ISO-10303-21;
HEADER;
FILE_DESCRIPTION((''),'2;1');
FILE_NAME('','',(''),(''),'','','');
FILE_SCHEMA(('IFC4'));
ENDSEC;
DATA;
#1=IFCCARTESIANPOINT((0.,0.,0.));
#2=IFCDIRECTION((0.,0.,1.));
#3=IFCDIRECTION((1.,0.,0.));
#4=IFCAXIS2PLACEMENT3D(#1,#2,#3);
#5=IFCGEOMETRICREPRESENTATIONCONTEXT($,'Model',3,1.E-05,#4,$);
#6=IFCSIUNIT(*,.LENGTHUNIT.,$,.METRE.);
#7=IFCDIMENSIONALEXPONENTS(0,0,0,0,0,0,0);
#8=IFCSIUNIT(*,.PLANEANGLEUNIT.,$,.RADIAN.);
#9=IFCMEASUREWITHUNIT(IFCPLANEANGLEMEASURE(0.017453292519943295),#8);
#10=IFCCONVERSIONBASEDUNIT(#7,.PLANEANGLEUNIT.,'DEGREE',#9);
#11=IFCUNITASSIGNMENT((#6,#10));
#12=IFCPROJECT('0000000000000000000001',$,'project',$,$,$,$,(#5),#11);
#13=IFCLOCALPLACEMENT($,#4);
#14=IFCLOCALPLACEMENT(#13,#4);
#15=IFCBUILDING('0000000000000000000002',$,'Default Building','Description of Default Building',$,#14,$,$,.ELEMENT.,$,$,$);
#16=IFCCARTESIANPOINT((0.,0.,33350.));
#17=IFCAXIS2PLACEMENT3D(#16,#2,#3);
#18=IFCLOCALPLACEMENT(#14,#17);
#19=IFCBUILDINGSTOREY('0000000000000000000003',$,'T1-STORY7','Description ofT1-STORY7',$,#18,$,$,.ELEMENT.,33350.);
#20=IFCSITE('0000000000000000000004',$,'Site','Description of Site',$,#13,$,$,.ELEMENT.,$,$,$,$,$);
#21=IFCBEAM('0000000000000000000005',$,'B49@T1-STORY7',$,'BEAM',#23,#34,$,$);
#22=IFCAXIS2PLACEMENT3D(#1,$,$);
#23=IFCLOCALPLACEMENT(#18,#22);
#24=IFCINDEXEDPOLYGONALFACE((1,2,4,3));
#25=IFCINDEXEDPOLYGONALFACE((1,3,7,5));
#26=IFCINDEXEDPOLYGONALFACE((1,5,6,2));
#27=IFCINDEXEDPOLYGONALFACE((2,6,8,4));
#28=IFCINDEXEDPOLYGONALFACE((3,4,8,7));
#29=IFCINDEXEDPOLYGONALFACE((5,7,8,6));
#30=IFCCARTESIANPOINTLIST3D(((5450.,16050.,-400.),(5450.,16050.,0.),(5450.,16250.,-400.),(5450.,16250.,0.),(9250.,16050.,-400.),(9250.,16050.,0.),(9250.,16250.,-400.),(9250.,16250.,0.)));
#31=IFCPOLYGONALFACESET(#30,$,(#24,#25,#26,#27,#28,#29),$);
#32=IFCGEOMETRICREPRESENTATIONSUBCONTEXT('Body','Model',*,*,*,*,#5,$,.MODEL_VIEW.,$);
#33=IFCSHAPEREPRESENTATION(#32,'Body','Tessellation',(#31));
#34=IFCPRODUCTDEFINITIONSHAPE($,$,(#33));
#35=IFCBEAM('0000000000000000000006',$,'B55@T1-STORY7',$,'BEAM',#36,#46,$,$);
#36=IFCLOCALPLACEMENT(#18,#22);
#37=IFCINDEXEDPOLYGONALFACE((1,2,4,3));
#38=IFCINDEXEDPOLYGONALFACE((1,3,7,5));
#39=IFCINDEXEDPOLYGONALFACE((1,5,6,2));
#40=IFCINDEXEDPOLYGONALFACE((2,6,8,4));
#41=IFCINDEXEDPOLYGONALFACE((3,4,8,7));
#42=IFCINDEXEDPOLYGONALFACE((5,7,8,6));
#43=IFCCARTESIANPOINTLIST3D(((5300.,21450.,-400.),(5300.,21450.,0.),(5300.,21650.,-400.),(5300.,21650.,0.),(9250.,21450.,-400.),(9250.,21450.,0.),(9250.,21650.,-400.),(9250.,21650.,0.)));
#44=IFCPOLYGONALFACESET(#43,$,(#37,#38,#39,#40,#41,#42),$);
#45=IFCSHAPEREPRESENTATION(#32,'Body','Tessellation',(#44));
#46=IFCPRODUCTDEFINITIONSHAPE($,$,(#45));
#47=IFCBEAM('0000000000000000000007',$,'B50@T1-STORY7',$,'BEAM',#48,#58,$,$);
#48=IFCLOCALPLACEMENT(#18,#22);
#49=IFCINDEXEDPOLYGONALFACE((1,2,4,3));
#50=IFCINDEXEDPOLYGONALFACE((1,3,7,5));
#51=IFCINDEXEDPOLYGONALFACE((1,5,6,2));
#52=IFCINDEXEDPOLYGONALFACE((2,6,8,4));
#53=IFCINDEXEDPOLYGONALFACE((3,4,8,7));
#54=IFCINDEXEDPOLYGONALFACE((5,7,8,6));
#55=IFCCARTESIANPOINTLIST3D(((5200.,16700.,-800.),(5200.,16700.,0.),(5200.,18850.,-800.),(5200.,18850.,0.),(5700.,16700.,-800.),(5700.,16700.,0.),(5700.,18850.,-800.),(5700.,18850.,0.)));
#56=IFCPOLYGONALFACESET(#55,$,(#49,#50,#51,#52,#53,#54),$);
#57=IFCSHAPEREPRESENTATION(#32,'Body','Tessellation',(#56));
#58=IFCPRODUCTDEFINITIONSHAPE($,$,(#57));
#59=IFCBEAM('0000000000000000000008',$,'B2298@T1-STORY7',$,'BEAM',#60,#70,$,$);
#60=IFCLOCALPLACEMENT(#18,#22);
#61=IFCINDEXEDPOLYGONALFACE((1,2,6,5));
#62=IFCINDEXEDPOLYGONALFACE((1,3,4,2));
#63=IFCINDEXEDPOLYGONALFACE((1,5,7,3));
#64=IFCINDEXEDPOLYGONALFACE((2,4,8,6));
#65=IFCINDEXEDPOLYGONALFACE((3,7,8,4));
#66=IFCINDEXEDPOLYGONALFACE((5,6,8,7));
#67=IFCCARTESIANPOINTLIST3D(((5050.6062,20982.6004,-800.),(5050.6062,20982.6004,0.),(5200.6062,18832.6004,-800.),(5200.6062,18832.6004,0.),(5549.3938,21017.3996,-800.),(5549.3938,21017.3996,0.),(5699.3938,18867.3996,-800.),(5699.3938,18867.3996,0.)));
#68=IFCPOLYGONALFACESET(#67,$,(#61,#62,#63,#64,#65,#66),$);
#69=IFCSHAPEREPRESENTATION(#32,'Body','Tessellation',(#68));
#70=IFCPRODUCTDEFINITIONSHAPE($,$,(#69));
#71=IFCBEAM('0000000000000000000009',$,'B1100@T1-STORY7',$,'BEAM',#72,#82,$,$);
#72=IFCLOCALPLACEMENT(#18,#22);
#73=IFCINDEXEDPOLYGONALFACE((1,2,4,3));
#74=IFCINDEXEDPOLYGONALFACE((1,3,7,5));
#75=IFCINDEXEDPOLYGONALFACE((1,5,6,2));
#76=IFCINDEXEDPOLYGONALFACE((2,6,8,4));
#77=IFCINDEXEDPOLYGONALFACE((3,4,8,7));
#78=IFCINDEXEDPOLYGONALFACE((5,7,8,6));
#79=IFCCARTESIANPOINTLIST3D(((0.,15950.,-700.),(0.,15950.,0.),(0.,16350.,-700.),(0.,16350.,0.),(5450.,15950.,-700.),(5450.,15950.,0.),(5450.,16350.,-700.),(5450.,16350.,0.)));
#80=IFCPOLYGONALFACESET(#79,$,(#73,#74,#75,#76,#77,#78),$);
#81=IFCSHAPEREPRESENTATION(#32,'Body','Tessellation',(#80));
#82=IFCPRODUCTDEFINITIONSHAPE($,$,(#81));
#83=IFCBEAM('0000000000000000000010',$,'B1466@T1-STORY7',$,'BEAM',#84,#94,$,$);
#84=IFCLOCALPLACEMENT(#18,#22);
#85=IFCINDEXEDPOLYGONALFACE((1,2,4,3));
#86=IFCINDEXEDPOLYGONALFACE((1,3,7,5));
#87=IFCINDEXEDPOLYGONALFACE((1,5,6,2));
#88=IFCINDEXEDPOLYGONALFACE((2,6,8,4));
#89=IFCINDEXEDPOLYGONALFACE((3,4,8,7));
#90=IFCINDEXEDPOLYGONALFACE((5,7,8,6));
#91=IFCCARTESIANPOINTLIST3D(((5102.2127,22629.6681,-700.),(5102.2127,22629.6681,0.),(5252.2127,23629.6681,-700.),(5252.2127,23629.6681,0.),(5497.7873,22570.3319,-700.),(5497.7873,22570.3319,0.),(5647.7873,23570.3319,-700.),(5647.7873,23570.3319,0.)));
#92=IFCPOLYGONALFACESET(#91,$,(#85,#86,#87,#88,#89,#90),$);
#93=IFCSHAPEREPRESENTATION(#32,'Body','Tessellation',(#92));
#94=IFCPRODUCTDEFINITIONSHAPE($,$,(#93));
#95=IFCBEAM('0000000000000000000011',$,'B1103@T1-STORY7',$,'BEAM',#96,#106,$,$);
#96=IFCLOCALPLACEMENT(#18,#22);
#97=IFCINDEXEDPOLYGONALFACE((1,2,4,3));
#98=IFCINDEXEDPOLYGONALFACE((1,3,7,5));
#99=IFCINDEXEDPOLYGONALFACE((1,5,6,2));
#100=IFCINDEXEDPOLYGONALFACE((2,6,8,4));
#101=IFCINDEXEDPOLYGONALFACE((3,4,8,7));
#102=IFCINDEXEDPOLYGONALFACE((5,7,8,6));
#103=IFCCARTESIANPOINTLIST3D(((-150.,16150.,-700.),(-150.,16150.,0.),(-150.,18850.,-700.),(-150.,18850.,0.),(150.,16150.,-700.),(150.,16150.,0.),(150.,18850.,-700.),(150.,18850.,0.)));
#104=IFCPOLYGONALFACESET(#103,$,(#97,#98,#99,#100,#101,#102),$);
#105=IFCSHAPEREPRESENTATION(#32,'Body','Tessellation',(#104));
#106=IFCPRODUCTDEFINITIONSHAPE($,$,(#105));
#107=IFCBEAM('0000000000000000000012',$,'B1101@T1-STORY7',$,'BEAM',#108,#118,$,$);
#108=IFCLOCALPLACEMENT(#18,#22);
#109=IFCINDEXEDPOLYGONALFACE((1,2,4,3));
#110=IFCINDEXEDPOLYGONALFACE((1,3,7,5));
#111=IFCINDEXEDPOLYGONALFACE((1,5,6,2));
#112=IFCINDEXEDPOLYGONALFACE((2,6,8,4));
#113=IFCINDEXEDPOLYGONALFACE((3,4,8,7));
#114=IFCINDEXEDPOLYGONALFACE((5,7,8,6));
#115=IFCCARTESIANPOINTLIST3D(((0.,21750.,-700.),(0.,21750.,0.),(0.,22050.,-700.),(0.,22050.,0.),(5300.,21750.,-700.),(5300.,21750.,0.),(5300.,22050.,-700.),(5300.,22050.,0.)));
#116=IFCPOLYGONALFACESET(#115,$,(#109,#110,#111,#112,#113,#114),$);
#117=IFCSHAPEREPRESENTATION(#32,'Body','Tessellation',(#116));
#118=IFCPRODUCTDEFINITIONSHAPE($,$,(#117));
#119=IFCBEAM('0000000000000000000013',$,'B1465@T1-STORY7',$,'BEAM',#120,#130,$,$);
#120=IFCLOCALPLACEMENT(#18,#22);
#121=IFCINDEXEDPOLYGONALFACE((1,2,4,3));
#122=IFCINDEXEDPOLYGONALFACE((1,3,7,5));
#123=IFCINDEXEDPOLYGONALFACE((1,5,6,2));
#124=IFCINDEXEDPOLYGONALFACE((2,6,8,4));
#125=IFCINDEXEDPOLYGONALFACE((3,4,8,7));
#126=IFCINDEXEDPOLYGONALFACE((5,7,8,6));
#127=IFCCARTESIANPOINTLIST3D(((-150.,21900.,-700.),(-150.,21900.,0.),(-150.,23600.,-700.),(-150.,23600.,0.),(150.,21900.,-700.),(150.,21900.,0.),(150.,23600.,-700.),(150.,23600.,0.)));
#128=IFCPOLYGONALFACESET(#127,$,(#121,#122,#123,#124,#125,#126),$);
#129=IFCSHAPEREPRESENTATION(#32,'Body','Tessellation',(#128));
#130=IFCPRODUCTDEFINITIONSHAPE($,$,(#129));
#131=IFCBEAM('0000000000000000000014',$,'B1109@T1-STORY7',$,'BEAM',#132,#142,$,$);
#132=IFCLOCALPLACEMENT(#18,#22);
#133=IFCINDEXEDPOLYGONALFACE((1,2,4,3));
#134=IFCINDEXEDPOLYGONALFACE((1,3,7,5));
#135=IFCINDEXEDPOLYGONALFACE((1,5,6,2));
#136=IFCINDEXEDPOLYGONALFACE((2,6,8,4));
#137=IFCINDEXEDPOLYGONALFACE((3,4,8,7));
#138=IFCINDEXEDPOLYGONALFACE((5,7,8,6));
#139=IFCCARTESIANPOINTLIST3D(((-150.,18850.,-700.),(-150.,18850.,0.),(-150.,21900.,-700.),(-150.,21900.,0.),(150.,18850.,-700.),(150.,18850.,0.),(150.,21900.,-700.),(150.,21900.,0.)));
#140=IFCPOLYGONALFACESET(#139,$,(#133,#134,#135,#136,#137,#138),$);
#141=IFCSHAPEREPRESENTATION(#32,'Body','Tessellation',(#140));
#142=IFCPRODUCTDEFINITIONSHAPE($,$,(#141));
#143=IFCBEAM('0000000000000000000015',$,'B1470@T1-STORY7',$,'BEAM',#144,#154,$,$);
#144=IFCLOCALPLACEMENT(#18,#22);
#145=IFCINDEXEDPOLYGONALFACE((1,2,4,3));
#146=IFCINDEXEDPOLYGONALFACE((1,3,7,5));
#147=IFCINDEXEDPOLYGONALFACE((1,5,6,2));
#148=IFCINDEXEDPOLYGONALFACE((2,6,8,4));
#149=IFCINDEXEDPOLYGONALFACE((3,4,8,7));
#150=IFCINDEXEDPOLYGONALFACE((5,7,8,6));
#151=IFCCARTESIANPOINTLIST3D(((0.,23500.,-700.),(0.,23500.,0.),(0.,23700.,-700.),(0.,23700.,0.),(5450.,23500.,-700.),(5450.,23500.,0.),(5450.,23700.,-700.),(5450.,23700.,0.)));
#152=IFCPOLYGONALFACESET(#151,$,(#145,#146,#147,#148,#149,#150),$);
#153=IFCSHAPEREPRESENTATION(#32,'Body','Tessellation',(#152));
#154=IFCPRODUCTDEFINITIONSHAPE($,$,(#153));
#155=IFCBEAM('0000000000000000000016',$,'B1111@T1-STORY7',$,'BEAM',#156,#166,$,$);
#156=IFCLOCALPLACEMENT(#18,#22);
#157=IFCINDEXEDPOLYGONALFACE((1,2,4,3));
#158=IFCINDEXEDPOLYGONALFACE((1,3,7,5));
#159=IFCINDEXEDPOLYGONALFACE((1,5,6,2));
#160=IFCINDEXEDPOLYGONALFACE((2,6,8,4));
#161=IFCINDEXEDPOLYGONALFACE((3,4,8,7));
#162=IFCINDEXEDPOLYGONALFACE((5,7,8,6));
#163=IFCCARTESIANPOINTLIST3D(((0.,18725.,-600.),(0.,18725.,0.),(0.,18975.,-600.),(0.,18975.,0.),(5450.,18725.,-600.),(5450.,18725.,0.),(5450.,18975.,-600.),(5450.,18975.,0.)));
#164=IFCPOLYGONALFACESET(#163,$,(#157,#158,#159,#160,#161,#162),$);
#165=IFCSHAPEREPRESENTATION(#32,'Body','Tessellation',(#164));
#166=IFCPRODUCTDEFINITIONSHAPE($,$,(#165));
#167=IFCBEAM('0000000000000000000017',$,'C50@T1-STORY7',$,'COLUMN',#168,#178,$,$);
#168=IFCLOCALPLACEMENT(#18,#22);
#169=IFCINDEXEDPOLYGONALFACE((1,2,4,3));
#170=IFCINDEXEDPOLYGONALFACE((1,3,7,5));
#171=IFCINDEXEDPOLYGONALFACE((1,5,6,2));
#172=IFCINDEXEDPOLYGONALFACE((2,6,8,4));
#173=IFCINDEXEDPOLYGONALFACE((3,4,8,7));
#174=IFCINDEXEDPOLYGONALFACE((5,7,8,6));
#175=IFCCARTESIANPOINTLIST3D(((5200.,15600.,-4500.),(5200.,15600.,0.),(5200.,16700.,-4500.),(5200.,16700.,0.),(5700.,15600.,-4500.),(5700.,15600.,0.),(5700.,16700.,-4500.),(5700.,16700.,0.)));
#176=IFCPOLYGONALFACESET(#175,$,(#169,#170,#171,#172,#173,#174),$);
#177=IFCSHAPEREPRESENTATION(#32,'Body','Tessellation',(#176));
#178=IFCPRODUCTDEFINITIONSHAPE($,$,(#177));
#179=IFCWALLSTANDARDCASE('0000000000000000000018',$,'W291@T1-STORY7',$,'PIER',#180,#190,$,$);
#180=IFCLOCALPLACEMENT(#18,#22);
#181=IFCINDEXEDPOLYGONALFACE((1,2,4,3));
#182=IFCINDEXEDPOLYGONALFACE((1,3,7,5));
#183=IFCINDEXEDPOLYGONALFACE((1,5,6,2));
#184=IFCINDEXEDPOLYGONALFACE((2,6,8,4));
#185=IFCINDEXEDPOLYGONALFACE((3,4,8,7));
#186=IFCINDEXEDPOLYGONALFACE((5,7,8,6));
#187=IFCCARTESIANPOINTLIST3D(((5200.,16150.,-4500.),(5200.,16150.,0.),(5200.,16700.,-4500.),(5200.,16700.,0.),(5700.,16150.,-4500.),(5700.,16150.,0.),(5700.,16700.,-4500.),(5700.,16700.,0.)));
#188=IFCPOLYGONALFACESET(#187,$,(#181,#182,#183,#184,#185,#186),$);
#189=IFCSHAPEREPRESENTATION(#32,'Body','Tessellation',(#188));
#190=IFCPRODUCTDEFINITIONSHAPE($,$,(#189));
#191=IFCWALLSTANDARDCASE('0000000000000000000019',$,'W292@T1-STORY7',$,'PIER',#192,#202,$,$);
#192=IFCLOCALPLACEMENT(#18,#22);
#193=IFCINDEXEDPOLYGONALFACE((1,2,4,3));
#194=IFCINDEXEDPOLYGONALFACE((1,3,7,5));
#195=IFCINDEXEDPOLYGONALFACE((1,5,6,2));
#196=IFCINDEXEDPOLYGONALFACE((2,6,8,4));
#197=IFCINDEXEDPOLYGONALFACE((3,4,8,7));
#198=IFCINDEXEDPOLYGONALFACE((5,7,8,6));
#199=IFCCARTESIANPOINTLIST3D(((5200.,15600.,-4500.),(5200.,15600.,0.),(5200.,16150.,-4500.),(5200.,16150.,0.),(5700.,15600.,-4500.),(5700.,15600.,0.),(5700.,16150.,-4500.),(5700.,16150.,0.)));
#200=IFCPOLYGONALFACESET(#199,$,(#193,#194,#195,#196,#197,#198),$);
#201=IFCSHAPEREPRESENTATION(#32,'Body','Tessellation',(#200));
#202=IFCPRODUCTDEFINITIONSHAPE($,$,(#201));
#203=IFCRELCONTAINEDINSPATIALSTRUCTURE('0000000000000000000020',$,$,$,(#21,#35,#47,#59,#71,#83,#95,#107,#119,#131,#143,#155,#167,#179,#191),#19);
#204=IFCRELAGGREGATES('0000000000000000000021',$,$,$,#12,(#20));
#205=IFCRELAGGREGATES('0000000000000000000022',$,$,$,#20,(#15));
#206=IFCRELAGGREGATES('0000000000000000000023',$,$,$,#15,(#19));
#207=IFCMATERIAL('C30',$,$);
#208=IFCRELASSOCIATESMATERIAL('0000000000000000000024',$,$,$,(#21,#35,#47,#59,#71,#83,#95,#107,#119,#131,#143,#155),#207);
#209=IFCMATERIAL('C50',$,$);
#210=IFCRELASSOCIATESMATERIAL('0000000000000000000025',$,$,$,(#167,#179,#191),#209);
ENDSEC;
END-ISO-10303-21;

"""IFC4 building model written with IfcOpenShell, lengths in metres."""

from ifc_helpers import new_model, entity, si_unit, converted_unit, frame, origin_with_axes, place, context, subcontext, project, spatial, indexed_curve, rectangle, outline, extrude, material, element, save


model = new_model("IFC4")

# Units and contexts
model_context = context("Model", 3, precision=1e-05, world=origin_with_axes())
body_context = subcontext(model_context, "Body", "Model", "MODEL_VIEW")
ifc_project = project(units=[si_unit("LENGTHUNIT", "METRE"), converted_unit("PLANEANGLEUNIT", "DEGREE", entity("IfcPlaneAngleMeasure", 0.017453292519943295), si_unit("PLANEANGLEUNIT", "RADIAN"), dimensions=[0, 0, 0, 0, 0, 0, 0])], contexts=[model_context])

# Site, building, storey
site_placement = place(None, origin_with_axes())
site = spatial("IfcSite", under=ifc_project, at=site_placement, Name="Site", Description="Description of Site", CompositionType="ELEMENT")
building_placement = place(site_placement, origin_with_axes())
building = spatial("IfcBuilding", under=site, at=building_placement, Name="Default Building", Description="Description of Default Building", CompositionType="ELEMENT")
storey_placement = place(building_placement, frame((0.0, 0.0, 33350.0), z_axis=(0.0, 0.0, 1.0), x_axis=(1.0, 0.0, 0.0)))
storey = spatial("IfcBuildingStorey", under=building, at=storey_placement, Name="T1-STORY7", Description="Description ofT1-STORY7", CompositionType="ELEMENT", Elevation=33350.0)

# Beams
ifc_material_1 = material(Name="C30")
beam_1_placement = place(storey_placement, frame((5450.0, 16150.0, -200.0), z_axis=(1.0, 0.0, 0.0), x_axis=(0.0, 1.0, 0.0)))
element("IfcBeam", 1, at=beam_1_placement, inside=storey, material=ifc_material_1, Name="B49@T1-STORY7", ObjectType="BEAM", context=body_context, shape_type="SweptSolid", body=[
    extrude(rectangle(XDim=200.0, YDim=400.0), origin_with_axes(), (0.0, 0.0, 1.0), 3800.0),
])
beam_2_placement = place(storey_placement, frame((5300.0, 21550.0, -200.0), z_axis=(1.0, 0.0, 0.0), x_axis=(0.0, 1.0, 0.0)))
element("IfcBeam", 2, at=beam_2_placement, inside=storey, material=ifc_material_1, Name="B55@T1-STORY7", ObjectType="BEAM", context=body_context, shape_type="SweptSolid", body=[
    extrude(rectangle(XDim=200.0, YDim=400.0), origin_with_axes(), (0.0, 0.0, 1.0), 3950.0),
])
beam_3_placement = place(storey_placement, frame((5450.0, 16700.0, -400.0), z_axis=(0.0, 1.0, 0.0), x_axis=(-1.0, 0.0, 0.0)))
element("IfcBeam", 3, at=beam_3_placement, inside=storey, material=ifc_material_1, Name="B50@T1-STORY7", ObjectType="BEAM", context=body_context, shape_type="SweptSolid", body=[
    extrude(rectangle(XDim=500.0, YDim=800.0), origin_with_axes(), (0.0, 0.0, 1.0), 2150.0),
])
beam_4_placement = place(storey_placement, frame((5300.0, 21000.0, -400.0), z_axis=(0.069598, -0.997575, 0.0), x_axis=(0.997575, 0.069598, 0.0)))
element("IfcBeam", 4, at=beam_4_placement, inside=storey, material=ifc_material_1, Name="B2298@T1-STORY7", ObjectType="BEAM", context=body_context, shape_type="SweptSolid", body=[
    extrude(rectangle(XDim=500.0, YDim=800.0), origin_with_axes(), (0.0, 0.0, 1.0), 2155.2262),
])
beam_5_placement = place(storey_placement, frame((0.0, 16150.0, -350.0), z_axis=(1.0, 0.0, 0.0), x_axis=(0.0, 1.0, 0.0)))
element("IfcBeam", 5, at=beam_5_placement, inside=storey, material=ifc_material_1, Name="B1100@T1-STORY7", ObjectType="BEAM", context=body_context, shape_type="SweptSolid", body=[
    extrude(rectangle(XDim=400.0, YDim=700.0), origin_with_axes(), (0.0, 0.0, 1.0), 5450.0),
])
beam_6_placement = place(storey_placement, frame((5300.0, 22600.0, -350.0), z_axis=(0.14834, 0.988936, 0.0), x_axis=(-0.988936, 0.14834, 0.0)))
element("IfcBeam", 6, at=beam_6_placement, inside=storey, material=ifc_material_1, Name="B1466@T1-STORY7", ObjectType="BEAM", context=body_context, shape_type="SweptSolid", body=[
    extrude(rectangle(XDim=400.0, YDim=700.0), origin_with_axes(), (0.0, 0.0, 1.0), 1011.1874),
])
beam_7_placement = place(storey_placement, frame((0.0, 16150.0, -350.0), z_axis=(0.0, 1.0, 0.0), x_axis=(-1.0, 0.0, 0.0)))
element("IfcBeam", 7, at=beam_7_placement, inside=storey, material=ifc_material_1, Name="B1103@T1-STORY7", ObjectType="BEAM", context=body_context, shape_type="SweptSolid", body=[
    extrude(rectangle(XDim=300.0, YDim=700.0), origin_with_axes(), (0.0, 0.0, 1.0), 2700.0),
])
beam_8_placement = place(storey_placement, frame((0.0, 21900.0, -350.0), z_axis=(1.0, 0.0, 0.0), x_axis=(0.0, 1.0, 0.0)))
element("IfcBeam", 8, at=beam_8_placement, inside=storey, material=ifc_material_1, Name="B1101@T1-STORY7", ObjectType="BEAM", context=body_context, shape_type="SweptSolid", body=[
    extrude(rectangle(XDim=300.0, YDim=700.0), origin_with_axes(), (0.0, 0.0, 1.0), 5300.0),
])
beam_9_placement = place(storey_placement, frame((0.0, 21900.0, -350.0), z_axis=(0.0, 1.0, 0.0), x_axis=(-1.0, 0.0, 0.0)))
element("IfcBeam", 9, at=beam_9_placement, inside=storey, material=ifc_material_1, Name="B1465@T1-STORY7", ObjectType="BEAM", context=body_context, shape_type="SweptSolid", body=[
    extrude(rectangle(XDim=300.0, YDim=700.0), origin_with_axes(), (0.0, 0.0, 1.0), 1700.0),
])
beam_10_placement = place(storey_placement, frame((0.0, 18850.0, -350.0), z_axis=(0.0, 1.0, 0.0), x_axis=(-1.0, 0.0, 0.0)))
element("IfcBeam", 10, at=beam_10_placement, inside=storey, material=ifc_material_1, Name="B1109@T1-STORY7", ObjectType="BEAM", context=body_context, shape_type="SweptSolid", body=[
    extrude(rectangle(XDim=300.0, YDim=700.0), origin_with_axes(), (0.0, 0.0, 1.0), 3050.0),
])
beam_11_placement = place(storey_placement, frame((0.0, 23600.0, -350.0), z_axis=(1.0, 0.0, 0.0), x_axis=(0.0, 1.0, 0.0)))
element("IfcBeam", 11, at=beam_11_placement, inside=storey, material=ifc_material_1, Name="B1470@T1-STORY7", ObjectType="BEAM", context=body_context, shape_type="SweptSolid", body=[
    extrude(rectangle(XDim=200.0, YDim=700.0), origin_with_axes(), (0.0, 0.0, 1.0), 5450.0),
])
beam_12_placement = place(storey_placement, frame((0.0, 18850.0, -300.0), z_axis=(1.0, 0.0, 0.0), x_axis=(0.0, 1.0, 0.0)))
element("IfcBeam", 12, at=beam_12_placement, inside=storey, material=ifc_material_1, Name="B1111@T1-STORY7", ObjectType="BEAM", context=body_context, shape_type="SweptSolid", body=[
    extrude(rectangle(XDim=250.0, YDim=600.0), origin_with_axes(), (0.0, 0.0, 1.0), 5450.0),
])
ifc_material_2 = material(Name="C50")
beam_13_placement = place(storey_placement, frame((5450.0, 16150.0, -4500.0), z_axis=(0.0, 0.0, 1.0), x_axis=(-1.0, 0.0, 0.0)))
element("IfcBeam", 13, at=beam_13_placement, inside=storey, material=ifc_material_2, Name="C50@T1-STORY7", ObjectType="COLUMN", context=body_context, shape_type="SweptSolid", body=[
    extrude(rectangle(XDim=500.0, YDim=1100.0), origin_with_axes(), (0.0, 0.0, 1.0), 4500.0),
])

# Walls
for number, where, z_axis, x_axis, name in (
    (14, (5450.0, 16150.0, -4500.0), (0.0, 0.0, 1.0), (0.0, 1.0, 0.0), "W291@T1-STORY7"),
    (15, (5450.0, 15600.0, -4500.0), (0.0, 0.0, 1.0), (0.0, 1.0, 0.0), "W292@T1-STORY7"),
):
    element("IfcWallStandardCase", number, at=place(storey_placement, frame(where, z_axis=z_axis, x_axis=x_axis)), inside=storey, material=ifc_material_2, Name=name, ObjectType="PIER", context=body_context, shape_type="SweptSolid", body=[
        extrude(outline(indexed_curve([(0.0, -250.0), (0.0, 250.0), (550.0, 250.0), (550.0, -250.0), (0.0, -250.0)], self_intersect=False)), origin_with_axes(), (0.0, 0.0, 1.0), 4500.0),
    ])

save(model, "model.ifc")
